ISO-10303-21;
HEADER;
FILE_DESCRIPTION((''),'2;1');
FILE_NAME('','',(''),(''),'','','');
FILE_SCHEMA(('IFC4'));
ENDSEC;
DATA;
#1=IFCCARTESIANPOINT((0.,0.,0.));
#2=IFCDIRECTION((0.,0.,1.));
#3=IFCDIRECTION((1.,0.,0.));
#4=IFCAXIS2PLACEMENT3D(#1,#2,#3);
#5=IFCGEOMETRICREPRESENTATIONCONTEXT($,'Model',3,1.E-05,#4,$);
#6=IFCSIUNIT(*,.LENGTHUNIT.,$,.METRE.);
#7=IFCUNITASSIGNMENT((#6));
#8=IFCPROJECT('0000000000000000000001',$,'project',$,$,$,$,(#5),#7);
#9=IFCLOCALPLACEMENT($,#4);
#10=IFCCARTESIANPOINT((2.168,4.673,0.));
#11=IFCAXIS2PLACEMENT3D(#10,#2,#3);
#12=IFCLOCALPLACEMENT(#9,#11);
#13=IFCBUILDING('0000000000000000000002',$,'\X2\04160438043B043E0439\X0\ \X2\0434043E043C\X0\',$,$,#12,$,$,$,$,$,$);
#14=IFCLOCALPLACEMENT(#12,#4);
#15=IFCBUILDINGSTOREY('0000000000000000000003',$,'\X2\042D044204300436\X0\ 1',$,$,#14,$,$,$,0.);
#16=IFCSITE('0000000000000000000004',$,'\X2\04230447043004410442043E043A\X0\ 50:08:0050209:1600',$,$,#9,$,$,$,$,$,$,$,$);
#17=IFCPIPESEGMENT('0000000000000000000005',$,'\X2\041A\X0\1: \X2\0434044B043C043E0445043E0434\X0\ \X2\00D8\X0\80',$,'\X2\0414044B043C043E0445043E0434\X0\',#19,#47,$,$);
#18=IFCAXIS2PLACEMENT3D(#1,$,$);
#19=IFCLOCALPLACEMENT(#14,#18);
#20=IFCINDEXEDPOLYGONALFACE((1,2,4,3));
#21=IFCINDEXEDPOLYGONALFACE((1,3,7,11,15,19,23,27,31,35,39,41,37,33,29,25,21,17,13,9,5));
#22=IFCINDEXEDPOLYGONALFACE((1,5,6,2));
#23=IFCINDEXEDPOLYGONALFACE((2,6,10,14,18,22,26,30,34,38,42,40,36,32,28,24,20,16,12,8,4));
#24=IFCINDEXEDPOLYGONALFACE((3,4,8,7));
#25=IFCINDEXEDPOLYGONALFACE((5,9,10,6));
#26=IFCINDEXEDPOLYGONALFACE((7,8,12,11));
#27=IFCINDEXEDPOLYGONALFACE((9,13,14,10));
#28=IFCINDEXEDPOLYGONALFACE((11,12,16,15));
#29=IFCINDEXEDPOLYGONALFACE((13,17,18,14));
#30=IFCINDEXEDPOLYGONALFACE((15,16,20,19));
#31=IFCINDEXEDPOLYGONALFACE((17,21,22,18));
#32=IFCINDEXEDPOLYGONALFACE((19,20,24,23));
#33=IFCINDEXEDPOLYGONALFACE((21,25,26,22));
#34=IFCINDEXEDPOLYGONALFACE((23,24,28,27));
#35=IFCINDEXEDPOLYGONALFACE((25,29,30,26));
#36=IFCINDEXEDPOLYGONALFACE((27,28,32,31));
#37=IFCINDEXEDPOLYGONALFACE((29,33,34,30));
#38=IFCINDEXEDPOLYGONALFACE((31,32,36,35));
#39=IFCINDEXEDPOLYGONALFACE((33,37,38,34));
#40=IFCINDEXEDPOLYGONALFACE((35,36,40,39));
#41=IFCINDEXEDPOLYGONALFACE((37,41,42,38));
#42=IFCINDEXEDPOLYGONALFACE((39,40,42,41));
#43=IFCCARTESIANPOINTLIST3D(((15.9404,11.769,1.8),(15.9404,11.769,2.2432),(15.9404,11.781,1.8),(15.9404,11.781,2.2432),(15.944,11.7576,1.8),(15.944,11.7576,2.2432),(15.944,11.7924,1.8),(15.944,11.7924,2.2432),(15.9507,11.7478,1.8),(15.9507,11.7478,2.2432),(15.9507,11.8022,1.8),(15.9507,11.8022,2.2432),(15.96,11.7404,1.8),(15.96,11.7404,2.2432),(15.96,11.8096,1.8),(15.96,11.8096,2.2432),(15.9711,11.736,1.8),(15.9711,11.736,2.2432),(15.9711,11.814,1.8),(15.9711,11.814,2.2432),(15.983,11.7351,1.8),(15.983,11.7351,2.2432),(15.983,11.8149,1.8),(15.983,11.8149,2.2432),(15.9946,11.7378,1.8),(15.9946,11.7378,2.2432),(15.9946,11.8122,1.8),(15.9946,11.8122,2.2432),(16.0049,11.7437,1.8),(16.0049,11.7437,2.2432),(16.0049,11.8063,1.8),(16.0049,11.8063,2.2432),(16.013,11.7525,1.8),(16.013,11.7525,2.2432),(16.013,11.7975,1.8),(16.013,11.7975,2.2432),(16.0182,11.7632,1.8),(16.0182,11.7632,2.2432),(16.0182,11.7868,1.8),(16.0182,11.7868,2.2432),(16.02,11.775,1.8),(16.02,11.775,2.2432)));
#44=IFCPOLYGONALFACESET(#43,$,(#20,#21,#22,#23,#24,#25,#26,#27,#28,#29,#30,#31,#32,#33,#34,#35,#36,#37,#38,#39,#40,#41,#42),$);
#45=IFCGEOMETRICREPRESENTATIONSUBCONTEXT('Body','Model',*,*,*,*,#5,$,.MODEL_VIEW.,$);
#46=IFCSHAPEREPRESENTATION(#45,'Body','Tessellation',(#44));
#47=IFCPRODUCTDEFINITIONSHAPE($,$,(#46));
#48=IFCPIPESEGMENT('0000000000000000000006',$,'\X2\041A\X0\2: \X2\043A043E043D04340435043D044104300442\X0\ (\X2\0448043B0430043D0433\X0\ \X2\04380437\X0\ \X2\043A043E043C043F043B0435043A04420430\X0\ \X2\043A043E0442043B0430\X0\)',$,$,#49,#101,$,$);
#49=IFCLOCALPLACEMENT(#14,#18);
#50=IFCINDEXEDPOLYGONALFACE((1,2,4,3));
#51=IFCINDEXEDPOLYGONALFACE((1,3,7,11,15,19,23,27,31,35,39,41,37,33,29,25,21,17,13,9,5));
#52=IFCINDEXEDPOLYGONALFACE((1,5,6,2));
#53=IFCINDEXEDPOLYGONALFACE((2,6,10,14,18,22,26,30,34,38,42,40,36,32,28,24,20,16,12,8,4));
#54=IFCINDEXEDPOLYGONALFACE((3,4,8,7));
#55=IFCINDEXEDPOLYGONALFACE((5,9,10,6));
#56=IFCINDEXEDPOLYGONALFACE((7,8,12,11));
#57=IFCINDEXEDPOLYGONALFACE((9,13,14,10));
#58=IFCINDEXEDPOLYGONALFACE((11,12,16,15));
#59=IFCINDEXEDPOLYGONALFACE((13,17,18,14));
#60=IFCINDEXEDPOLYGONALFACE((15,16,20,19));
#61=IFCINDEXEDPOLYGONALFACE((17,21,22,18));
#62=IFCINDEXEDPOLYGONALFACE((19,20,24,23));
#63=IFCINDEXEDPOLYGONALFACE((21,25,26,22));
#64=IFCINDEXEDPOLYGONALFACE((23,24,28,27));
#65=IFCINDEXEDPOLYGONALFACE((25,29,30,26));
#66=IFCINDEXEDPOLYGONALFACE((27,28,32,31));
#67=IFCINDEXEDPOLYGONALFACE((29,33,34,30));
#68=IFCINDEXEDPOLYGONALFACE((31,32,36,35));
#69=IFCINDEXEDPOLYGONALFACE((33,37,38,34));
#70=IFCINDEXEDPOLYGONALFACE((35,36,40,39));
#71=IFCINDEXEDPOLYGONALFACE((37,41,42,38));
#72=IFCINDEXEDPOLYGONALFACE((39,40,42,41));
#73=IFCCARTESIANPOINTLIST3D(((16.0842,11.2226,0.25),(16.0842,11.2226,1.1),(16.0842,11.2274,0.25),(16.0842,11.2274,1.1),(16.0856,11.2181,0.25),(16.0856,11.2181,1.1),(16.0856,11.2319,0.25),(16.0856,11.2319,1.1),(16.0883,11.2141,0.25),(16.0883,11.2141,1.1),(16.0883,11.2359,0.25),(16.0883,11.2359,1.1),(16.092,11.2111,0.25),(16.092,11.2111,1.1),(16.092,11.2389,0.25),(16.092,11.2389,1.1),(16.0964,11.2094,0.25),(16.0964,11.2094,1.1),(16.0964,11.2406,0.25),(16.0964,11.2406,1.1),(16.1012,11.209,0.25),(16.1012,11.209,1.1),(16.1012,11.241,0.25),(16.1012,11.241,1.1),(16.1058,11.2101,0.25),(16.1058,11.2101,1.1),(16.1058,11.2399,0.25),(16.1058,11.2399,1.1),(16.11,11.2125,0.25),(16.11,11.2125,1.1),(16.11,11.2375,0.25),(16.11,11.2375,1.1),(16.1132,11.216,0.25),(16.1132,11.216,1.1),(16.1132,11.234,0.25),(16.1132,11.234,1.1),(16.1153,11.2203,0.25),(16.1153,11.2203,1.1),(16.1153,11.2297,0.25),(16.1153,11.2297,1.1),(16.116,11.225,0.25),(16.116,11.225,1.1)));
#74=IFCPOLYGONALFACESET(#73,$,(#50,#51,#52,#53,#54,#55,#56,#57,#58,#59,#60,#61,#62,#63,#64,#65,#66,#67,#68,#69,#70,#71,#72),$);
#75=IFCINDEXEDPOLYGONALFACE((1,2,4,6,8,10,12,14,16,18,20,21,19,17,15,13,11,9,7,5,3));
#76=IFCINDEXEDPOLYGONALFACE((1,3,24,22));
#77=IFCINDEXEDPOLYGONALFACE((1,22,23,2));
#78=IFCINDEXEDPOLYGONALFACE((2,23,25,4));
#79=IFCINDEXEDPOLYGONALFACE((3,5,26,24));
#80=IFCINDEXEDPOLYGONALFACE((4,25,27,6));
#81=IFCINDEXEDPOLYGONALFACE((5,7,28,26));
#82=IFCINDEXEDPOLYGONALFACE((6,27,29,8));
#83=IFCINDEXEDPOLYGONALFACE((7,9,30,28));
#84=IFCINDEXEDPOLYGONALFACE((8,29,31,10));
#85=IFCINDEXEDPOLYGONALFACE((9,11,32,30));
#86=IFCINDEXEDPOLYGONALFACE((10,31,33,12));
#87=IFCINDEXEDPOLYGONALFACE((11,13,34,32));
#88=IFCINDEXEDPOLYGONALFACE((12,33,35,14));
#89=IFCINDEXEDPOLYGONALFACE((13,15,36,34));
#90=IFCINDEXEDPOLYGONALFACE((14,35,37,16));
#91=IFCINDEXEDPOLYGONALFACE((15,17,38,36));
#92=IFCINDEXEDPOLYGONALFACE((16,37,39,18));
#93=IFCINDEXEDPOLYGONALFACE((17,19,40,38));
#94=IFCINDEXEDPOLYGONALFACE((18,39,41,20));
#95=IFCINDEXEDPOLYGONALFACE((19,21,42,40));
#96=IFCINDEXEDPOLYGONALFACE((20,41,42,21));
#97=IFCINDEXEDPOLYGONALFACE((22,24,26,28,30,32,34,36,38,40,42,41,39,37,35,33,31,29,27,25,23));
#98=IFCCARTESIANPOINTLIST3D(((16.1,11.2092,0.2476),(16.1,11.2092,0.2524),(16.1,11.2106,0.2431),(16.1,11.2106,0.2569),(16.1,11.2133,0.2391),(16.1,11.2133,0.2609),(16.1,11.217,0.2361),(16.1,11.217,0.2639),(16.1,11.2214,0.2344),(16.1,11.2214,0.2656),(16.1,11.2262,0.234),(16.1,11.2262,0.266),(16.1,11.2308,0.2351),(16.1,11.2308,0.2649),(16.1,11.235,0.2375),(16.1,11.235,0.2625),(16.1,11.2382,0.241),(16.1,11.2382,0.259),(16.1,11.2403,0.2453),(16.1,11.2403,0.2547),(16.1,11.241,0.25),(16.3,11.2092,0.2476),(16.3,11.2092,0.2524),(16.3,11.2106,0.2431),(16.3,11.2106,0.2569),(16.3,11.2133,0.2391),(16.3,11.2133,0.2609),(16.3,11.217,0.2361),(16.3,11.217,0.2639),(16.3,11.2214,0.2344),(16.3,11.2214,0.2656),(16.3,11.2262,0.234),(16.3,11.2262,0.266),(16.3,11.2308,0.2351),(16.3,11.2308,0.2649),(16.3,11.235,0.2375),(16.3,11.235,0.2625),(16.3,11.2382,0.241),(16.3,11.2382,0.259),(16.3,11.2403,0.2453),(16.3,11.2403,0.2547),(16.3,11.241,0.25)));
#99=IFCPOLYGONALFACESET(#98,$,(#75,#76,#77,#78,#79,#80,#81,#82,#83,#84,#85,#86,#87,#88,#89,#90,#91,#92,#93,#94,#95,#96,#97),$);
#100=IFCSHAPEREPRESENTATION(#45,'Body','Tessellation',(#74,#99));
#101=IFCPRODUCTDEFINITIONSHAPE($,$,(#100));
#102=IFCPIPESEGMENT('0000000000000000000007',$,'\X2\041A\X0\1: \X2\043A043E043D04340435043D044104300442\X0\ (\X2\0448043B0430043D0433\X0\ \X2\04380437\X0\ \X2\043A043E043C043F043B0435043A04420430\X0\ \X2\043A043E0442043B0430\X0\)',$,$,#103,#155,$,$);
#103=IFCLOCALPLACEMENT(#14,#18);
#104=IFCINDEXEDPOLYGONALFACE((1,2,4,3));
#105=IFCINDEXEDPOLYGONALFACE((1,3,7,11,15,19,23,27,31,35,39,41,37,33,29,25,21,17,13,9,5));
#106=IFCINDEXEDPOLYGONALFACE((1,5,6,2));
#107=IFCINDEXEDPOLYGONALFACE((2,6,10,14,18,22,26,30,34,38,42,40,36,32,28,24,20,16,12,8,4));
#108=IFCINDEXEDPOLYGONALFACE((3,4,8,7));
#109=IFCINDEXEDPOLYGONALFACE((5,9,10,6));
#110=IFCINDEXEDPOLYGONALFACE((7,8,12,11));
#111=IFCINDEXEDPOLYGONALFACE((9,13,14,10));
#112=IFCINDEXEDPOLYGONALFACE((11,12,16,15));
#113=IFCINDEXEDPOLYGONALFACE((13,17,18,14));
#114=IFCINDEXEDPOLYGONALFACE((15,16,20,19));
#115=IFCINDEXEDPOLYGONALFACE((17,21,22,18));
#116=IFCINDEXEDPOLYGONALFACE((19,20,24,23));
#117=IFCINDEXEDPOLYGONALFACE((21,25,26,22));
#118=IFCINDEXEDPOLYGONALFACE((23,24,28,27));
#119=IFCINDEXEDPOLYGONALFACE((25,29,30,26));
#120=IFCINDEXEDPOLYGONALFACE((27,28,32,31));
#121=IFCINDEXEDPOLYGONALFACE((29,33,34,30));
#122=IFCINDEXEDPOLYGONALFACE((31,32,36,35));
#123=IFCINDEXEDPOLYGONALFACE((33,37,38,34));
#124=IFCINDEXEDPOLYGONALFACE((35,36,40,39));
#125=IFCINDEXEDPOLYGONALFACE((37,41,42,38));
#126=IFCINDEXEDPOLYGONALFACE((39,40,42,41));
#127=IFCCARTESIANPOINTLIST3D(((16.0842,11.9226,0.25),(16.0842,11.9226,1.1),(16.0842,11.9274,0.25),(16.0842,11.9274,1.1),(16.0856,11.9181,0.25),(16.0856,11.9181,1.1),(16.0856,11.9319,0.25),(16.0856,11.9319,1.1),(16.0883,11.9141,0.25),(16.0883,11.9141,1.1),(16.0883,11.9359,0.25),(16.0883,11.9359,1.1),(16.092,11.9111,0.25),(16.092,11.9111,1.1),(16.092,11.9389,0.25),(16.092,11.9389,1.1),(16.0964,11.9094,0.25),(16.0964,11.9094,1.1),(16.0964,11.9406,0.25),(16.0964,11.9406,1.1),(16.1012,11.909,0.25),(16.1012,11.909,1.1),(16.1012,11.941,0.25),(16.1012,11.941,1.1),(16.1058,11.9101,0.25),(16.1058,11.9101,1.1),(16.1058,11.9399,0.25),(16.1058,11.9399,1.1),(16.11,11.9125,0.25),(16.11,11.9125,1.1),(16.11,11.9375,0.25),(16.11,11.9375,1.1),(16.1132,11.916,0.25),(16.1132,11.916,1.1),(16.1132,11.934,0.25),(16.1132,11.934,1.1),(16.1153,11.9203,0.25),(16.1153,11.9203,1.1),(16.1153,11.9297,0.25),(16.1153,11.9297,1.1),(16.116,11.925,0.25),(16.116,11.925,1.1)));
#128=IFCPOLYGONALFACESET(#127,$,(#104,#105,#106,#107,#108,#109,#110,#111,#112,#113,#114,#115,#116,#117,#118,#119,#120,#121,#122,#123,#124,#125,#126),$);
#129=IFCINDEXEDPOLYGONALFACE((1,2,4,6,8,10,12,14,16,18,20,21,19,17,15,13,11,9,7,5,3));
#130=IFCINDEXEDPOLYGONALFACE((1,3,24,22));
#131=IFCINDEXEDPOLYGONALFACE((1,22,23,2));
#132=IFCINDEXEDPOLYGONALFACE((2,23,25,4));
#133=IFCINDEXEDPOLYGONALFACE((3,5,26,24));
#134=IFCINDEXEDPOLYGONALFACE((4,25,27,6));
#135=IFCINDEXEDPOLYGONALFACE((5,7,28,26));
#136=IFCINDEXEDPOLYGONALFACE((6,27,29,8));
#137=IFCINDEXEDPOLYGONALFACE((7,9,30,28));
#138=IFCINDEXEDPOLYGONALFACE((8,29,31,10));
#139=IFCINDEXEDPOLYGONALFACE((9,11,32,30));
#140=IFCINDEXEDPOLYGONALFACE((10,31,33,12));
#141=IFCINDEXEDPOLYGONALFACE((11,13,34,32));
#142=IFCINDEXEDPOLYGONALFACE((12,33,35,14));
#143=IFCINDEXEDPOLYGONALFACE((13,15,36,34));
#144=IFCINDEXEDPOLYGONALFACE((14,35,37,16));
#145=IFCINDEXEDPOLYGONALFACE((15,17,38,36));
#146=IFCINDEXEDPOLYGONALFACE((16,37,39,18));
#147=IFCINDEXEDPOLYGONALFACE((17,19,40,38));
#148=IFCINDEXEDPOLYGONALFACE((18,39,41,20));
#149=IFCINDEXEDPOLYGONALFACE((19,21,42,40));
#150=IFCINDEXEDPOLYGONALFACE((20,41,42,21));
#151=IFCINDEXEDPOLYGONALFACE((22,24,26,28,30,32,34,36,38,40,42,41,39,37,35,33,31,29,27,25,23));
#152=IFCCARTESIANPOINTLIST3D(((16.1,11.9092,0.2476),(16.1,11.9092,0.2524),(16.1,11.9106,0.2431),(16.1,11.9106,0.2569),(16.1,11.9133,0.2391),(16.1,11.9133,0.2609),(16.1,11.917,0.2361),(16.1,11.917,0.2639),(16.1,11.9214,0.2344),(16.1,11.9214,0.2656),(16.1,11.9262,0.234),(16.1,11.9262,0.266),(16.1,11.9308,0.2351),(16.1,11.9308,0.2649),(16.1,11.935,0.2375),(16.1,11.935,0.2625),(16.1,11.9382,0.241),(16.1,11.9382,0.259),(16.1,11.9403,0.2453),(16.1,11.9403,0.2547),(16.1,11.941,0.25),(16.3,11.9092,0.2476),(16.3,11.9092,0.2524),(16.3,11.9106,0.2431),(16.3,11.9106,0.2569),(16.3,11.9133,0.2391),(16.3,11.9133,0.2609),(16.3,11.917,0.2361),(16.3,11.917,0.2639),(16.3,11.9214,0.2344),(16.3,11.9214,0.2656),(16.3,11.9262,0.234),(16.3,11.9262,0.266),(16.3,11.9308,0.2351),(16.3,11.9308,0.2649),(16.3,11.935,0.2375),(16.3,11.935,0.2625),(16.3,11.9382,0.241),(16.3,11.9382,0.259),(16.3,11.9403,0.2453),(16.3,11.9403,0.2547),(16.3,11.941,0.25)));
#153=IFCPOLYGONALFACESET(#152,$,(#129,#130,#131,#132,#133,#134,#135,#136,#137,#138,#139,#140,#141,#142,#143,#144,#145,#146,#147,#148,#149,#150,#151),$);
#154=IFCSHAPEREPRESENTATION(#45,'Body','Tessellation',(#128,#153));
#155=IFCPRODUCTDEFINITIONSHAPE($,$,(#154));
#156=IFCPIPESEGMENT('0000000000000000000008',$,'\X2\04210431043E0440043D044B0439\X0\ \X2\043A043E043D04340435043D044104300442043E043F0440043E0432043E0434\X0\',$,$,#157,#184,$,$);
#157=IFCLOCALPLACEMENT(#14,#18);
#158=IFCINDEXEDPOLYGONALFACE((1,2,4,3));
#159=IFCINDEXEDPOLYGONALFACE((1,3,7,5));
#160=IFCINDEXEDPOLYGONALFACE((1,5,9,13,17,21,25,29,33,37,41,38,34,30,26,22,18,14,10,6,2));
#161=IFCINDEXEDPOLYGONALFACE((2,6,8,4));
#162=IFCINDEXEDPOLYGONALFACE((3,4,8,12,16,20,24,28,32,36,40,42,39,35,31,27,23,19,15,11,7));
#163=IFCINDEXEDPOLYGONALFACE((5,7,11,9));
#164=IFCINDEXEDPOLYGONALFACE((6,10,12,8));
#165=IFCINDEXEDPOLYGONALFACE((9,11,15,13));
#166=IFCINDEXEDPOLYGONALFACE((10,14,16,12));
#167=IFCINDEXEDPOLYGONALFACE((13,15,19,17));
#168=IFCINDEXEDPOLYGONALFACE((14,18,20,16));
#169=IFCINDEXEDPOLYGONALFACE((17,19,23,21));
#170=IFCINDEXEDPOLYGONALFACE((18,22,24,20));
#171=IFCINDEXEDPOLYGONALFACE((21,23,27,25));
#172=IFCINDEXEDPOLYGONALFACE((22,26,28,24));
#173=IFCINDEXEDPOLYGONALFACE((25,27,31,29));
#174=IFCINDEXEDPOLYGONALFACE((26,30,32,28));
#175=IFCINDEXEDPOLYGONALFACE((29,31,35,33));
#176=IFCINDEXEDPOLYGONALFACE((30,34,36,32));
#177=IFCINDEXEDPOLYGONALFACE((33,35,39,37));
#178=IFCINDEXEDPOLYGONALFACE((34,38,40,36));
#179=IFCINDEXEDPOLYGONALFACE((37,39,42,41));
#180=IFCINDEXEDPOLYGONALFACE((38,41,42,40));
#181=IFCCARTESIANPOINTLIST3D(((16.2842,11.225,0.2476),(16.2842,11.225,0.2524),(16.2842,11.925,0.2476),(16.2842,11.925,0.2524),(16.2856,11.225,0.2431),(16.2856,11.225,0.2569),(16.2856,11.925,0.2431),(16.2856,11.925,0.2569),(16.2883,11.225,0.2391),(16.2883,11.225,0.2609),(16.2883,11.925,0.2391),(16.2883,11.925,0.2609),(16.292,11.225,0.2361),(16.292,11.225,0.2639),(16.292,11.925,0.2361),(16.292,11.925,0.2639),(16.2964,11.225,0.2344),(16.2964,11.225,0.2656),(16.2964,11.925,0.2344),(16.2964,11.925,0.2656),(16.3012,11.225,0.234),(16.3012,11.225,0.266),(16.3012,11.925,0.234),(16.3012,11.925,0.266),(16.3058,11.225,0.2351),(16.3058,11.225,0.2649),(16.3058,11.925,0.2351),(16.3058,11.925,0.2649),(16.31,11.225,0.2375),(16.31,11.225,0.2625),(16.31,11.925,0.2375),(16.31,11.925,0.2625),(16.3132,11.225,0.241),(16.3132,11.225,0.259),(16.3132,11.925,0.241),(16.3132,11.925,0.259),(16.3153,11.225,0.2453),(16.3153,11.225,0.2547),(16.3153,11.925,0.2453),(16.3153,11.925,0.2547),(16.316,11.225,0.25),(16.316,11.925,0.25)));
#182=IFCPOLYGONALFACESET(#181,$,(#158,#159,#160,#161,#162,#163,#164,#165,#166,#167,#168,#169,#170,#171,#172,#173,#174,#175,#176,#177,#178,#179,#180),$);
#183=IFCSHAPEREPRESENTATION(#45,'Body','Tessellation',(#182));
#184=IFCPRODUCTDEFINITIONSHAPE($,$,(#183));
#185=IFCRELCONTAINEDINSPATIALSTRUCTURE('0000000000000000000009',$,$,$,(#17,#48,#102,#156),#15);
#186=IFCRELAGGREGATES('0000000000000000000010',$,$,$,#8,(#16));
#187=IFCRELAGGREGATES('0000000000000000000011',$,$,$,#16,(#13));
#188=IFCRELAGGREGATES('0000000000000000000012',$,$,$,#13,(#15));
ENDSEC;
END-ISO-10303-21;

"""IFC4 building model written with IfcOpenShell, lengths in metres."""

from ifc_helpers import new_model, si_unit, frame, origin_with_axes, origin_2d, place, context, subcontext, project, spatial, circle, extrude, element, save


model = new_model("IFC4")

# Units and contexts
model_context = context("Model", 3, precision=1e-05, world=origin_with_axes())
body_context = subcontext(model_context, "Body", "Model", "MODEL_VIEW")
ifc_project = project(units=[si_unit("LENGTHUNIT", "METRE")], contexts=[model_context])

# Site, building, storey
site_placement = place(None, origin_with_axes())
site = spatial("IfcSite", under=ifc_project, at=site_placement, Name="Участок 50:08:0050209:1600")
building_placement = place(site_placement, frame((2.168, 4.673, 0.0), z_axis=(0.0, 0.0, 1.0), x_axis=(1.0, 0.0, 0.0)))
building = spatial("IfcBuilding", under=site, at=building_placement, Name="Жилой дом")
storey_placement = place(building_placement, origin_with_axes())
storey = spatial("IfcBuildingStorey", under=building, at=storey_placement, Name="Этаж 1", Elevation=0.0)

# Pipe segments
pipe_segment_1_placement = place(storey_placement, origin_with_axes())
element("IfcPipeSegment", 1, at=pipe_segment_1_placement, inside=storey, Name="К1: дымоход Ø80", ObjectType="Дымоход", context=body_context, shape_type="SweptSolid", body=[
    extrude(circle(Radius=0.04, at=origin_2d()), frame((15.98, 11.775, 1.8), z_axis=(0.0, 0.0, 1.0), x_axis=(1.0, 0.0, 0.0)), (0.0, 0.0, 1.0), 0.4432),
])
pipe_segment_2_placement = place(storey_placement, origin_with_axes())
element("IfcPipeSegment", 2, at=pipe_segment_2_placement, inside=storey, Name="К2: конденсат (шланг из комплекта котла)", context=body_context, shape_type="SweptSolid", body=[
    extrude(circle(Radius=0.016, at=origin_2d()), frame((16.1, 11.225, 1.1), z_axis=(0.0, 0.0, -1.0), x_axis=(1.0, 0.0, 0.0)), (0.0, 0.0, 1.0), 0.85),
    extrude(circle(Radius=0.016, at=origin_2d()), frame((16.1, 11.225, 0.25), z_axis=(1.0, 0.0, 0.0), x_axis=(0.0, 1.0, 0.0)), (0.0, 0.0, 1.0), 0.2),
])
pipe_segment_3_placement = place(storey_placement, origin_with_axes())
element("IfcPipeSegment", 3, at=pipe_segment_3_placement, inside=storey, Name="К1: конденсат (шланг из комплекта котла)", context=body_context, shape_type="SweptSolid", body=[
    extrude(circle(Radius=0.016, at=origin_2d()), frame((16.1, 11.925, 1.1), z_axis=(0.0, 0.0, -1.0), x_axis=(1.0, 0.0, 0.0)), (0.0, 0.0, 1.0), 0.85),
    extrude(circle(Radius=0.016, at=origin_2d()), frame((16.1, 11.925, 0.25), z_axis=(1.0, 0.0, 0.0), x_axis=(0.0, 1.0, 0.0)), (0.0, 0.0, 1.0), 0.2),
])
pipe_segment_4_placement = place(storey_placement, origin_with_axes())
element("IfcPipeSegment", 4, at=pipe_segment_4_placement, inside=storey, Name="Сборный конденсатопровод", context=body_context, shape_type="SweptSolid", body=[
    extrude(circle(Radius=0.016, at=origin_2d()), frame((16.3, 11.925, 0.25), z_axis=(0.0, -1.0, 0.0), x_axis=(1.0, 0.0, 0.0)), (0.0, 0.0, 1.0), 0.7),
])

save(model, "model.ifc")
